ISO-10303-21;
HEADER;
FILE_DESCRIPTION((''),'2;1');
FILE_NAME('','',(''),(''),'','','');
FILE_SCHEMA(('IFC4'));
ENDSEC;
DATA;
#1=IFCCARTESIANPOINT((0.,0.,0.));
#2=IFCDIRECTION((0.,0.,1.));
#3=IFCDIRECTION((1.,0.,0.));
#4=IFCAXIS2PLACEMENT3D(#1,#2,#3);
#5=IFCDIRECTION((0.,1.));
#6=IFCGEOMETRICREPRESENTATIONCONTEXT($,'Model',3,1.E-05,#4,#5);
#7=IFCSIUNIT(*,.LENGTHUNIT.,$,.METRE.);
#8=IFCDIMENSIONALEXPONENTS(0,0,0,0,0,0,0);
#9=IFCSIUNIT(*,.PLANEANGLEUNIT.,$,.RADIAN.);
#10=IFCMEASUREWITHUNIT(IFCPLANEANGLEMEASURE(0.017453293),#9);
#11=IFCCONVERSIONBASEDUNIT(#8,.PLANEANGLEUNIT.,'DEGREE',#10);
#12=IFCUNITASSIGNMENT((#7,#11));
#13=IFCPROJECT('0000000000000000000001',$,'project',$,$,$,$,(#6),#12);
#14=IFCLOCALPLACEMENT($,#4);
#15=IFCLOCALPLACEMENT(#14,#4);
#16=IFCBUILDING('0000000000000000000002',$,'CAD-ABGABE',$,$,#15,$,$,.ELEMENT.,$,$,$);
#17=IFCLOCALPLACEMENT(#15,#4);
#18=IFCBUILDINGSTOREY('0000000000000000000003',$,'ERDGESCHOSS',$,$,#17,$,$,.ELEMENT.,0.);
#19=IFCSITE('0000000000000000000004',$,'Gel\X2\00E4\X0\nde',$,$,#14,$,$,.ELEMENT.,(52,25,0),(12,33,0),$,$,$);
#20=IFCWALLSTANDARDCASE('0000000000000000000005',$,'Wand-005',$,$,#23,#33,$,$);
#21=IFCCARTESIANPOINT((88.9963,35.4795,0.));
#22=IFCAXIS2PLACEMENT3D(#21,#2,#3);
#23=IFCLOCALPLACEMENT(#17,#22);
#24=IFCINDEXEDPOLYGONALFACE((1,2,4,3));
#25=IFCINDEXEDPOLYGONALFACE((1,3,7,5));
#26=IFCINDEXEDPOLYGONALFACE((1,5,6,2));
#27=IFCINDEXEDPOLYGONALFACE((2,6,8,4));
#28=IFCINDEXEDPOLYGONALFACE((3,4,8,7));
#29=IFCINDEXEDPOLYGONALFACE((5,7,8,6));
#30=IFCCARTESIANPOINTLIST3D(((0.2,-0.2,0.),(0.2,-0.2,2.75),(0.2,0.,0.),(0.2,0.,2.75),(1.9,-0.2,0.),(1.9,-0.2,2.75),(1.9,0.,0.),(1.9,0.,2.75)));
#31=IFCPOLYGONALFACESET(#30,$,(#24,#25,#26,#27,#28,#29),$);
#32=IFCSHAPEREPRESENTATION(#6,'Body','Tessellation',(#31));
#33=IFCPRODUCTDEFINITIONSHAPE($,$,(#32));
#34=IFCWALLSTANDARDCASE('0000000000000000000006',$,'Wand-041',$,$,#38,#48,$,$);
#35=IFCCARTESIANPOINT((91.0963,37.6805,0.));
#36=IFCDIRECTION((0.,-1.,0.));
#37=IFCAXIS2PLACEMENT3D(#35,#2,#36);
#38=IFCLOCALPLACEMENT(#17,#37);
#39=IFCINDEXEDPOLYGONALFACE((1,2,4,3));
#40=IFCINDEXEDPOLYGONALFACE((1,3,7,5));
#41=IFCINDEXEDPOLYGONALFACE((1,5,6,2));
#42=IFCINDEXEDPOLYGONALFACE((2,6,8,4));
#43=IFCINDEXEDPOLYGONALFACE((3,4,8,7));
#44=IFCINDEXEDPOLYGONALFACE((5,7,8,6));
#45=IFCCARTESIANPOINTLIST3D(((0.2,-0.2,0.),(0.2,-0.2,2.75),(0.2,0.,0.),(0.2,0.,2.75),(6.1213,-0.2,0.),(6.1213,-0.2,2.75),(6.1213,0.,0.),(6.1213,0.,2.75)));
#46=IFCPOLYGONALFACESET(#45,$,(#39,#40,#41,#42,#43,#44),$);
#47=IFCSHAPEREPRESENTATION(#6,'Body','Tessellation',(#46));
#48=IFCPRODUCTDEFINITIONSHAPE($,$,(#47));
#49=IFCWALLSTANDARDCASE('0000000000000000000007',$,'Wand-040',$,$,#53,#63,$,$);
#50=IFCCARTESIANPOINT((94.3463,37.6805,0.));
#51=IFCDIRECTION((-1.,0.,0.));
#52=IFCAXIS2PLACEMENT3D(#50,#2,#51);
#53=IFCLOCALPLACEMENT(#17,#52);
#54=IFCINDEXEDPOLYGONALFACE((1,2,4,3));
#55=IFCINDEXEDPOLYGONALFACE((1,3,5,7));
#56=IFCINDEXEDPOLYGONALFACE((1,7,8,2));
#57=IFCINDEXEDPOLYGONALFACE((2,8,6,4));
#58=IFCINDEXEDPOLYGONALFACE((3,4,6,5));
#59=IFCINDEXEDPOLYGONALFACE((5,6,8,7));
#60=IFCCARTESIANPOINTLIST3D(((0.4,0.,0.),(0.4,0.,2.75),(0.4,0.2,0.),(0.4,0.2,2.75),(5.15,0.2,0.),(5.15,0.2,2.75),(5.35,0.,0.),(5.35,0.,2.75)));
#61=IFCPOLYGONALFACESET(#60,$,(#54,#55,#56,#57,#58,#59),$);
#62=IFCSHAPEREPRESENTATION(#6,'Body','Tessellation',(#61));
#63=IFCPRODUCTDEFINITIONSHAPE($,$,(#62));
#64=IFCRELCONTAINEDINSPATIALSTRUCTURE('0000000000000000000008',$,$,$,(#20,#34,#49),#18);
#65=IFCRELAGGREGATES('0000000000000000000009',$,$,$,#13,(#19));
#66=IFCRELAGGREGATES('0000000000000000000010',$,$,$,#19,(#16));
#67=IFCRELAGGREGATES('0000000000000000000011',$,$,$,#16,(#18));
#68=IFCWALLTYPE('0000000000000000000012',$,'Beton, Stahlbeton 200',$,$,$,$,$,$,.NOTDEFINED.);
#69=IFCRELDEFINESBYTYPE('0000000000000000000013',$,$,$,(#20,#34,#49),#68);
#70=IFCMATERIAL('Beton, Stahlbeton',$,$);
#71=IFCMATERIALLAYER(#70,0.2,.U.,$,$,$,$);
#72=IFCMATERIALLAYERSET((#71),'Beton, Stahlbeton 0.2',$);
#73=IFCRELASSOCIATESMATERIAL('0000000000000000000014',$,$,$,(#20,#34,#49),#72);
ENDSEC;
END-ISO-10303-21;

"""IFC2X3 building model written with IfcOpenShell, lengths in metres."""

from ifc_helpers import new_model, entity, si_unit, converted_unit, direction, frame, origin_with_axes, place, context, project, spatial, polyline, outline, extrude, material, layer, layer_set, layer_usage, type_object, element, save


model = new_model("IFC2X3")

# Units and contexts
model_context = context("Model", 3, precision=1e-05, world=origin_with_axes(), true_north=direction((0.0, 1.0)))
ifc_project = project(units=[si_unit("LENGTHUNIT", "METRE"), converted_unit("PLANEANGLEUNIT", "DEGREE", entity("IfcPlaneAngleMeasure", 0.017453293), si_unit("PLANEANGLEUNIT", "RADIAN"), dimensions=[0, 0, 0, 0, 0, 0, 0])], contexts=[model_context])

# Site, building, storey
site_placement = place(None, origin_with_axes())
site = spatial("IfcSite", under=ifc_project, at=site_placement, Name="Gelände", CompositionType="ELEMENT", RefLatitude=(52, 25, 0), RefLongitude=(12, 33, 0))
building_placement = place(site_placement, origin_with_axes())
building = spatial("IfcBuilding", under=site, at=building_placement, Name="CAD-ABGABE", CompositionType="ELEMENT")
storey_placement = place(building_placement, origin_with_axes())
storey = spatial("IfcBuildingStorey", under=building, at=storey_placement, Name="ERDGESCHOSS", CompositionType="ELEMENT", Elevation=0.0)

# Shared definitions
ifc_material = material(Name="Beton, Stahlbeton")

# Walls
ifc_layer_1 = layer(ifc_material, 0.2, ventilated="UNKNOWN")
ifc_layer_set_1 = layer_set([ifc_layer_1], Name="Beton, Stahlbeton 0.2")
ifc_layer_usage_1 = layer_usage(ifc_layer_set_1, "AXIS2", "NEGATIVE", 0.0)
wall_type_1 = type_object("IfcWallType", Name="Beton, Stahlbeton 200", PredefinedType="NOTDEFINED")
wall_1_placement = place(storey_placement, frame((88.9963, 35.4795, 0.0), z_axis=(0.0, 0.0, 1.0), x_axis=(1.0, 0.0, 0.0)))
element("IfcWallStandardCase", 1, at=wall_1_placement, inside=storey, type_object=wall_type_1, material=ifc_layer_usage_1, Name="Wand-005", context=model_context, shape_type="SweptSolid", body=[
    extrude(outline(polyline([(0.2, -0.2), (1.9, -0.2), (1.9, 0.0), (0.2, 0.0), (0.2, -0.2)])), origin_with_axes(), (0.0, 0.0, 1.0), 2.75),
])
ifc_layer_usage_2 = layer_usage(ifc_layer_set_1, "AXIS2", "NEGATIVE", 0.0)
wall_2_placement = place(storey_placement, frame((91.0963, 37.6805, 0.0), z_axis=(0.0, 0.0, 1.0), x_axis=(0.0, -1.0, 0.0)))
element("IfcWallStandardCase", 2, at=wall_2_placement, inside=storey, type_object=wall_type_1, material=ifc_layer_usage_2, Name="Wand-041", context=model_context, shape_type="SweptSolid", body=[
    extrude(outline(polyline([(0.2, -0.2), (6.1213, -0.2), (6.1213, 0.0), (0.2, 0.0), (0.2, -0.2)])), origin_with_axes(), (0.0, 0.0, 1.0), 2.75),
])

# Wall
ifc_layer_usage_3 = layer_usage(ifc_layer_set_1, "AXIS2", "POSITIVE", 0.0)
wall_3_placement = place(storey_placement, frame((94.3463, 37.6805, 0.0), z_axis=(0.0, 0.0, 1.0), x_axis=(-1.0, 0.0, 0.0)))
element("IfcWallStandardCase", 3, at=wall_3_placement, inside=storey, type_object=wall_type_1, material=ifc_layer_usage_3, Name="Wand-040", context=model_context, shape_type="SweptSolid", body=[
    extrude(outline(polyline([(0.4, 0.0), (5.35, 0.0), (5.15, 0.2), (0.4, 0.2), (0.4, 0.0)])), origin_with_axes(), (0.0, 0.0, 1.0), 2.75),
])

save(model, "model.ifc")
